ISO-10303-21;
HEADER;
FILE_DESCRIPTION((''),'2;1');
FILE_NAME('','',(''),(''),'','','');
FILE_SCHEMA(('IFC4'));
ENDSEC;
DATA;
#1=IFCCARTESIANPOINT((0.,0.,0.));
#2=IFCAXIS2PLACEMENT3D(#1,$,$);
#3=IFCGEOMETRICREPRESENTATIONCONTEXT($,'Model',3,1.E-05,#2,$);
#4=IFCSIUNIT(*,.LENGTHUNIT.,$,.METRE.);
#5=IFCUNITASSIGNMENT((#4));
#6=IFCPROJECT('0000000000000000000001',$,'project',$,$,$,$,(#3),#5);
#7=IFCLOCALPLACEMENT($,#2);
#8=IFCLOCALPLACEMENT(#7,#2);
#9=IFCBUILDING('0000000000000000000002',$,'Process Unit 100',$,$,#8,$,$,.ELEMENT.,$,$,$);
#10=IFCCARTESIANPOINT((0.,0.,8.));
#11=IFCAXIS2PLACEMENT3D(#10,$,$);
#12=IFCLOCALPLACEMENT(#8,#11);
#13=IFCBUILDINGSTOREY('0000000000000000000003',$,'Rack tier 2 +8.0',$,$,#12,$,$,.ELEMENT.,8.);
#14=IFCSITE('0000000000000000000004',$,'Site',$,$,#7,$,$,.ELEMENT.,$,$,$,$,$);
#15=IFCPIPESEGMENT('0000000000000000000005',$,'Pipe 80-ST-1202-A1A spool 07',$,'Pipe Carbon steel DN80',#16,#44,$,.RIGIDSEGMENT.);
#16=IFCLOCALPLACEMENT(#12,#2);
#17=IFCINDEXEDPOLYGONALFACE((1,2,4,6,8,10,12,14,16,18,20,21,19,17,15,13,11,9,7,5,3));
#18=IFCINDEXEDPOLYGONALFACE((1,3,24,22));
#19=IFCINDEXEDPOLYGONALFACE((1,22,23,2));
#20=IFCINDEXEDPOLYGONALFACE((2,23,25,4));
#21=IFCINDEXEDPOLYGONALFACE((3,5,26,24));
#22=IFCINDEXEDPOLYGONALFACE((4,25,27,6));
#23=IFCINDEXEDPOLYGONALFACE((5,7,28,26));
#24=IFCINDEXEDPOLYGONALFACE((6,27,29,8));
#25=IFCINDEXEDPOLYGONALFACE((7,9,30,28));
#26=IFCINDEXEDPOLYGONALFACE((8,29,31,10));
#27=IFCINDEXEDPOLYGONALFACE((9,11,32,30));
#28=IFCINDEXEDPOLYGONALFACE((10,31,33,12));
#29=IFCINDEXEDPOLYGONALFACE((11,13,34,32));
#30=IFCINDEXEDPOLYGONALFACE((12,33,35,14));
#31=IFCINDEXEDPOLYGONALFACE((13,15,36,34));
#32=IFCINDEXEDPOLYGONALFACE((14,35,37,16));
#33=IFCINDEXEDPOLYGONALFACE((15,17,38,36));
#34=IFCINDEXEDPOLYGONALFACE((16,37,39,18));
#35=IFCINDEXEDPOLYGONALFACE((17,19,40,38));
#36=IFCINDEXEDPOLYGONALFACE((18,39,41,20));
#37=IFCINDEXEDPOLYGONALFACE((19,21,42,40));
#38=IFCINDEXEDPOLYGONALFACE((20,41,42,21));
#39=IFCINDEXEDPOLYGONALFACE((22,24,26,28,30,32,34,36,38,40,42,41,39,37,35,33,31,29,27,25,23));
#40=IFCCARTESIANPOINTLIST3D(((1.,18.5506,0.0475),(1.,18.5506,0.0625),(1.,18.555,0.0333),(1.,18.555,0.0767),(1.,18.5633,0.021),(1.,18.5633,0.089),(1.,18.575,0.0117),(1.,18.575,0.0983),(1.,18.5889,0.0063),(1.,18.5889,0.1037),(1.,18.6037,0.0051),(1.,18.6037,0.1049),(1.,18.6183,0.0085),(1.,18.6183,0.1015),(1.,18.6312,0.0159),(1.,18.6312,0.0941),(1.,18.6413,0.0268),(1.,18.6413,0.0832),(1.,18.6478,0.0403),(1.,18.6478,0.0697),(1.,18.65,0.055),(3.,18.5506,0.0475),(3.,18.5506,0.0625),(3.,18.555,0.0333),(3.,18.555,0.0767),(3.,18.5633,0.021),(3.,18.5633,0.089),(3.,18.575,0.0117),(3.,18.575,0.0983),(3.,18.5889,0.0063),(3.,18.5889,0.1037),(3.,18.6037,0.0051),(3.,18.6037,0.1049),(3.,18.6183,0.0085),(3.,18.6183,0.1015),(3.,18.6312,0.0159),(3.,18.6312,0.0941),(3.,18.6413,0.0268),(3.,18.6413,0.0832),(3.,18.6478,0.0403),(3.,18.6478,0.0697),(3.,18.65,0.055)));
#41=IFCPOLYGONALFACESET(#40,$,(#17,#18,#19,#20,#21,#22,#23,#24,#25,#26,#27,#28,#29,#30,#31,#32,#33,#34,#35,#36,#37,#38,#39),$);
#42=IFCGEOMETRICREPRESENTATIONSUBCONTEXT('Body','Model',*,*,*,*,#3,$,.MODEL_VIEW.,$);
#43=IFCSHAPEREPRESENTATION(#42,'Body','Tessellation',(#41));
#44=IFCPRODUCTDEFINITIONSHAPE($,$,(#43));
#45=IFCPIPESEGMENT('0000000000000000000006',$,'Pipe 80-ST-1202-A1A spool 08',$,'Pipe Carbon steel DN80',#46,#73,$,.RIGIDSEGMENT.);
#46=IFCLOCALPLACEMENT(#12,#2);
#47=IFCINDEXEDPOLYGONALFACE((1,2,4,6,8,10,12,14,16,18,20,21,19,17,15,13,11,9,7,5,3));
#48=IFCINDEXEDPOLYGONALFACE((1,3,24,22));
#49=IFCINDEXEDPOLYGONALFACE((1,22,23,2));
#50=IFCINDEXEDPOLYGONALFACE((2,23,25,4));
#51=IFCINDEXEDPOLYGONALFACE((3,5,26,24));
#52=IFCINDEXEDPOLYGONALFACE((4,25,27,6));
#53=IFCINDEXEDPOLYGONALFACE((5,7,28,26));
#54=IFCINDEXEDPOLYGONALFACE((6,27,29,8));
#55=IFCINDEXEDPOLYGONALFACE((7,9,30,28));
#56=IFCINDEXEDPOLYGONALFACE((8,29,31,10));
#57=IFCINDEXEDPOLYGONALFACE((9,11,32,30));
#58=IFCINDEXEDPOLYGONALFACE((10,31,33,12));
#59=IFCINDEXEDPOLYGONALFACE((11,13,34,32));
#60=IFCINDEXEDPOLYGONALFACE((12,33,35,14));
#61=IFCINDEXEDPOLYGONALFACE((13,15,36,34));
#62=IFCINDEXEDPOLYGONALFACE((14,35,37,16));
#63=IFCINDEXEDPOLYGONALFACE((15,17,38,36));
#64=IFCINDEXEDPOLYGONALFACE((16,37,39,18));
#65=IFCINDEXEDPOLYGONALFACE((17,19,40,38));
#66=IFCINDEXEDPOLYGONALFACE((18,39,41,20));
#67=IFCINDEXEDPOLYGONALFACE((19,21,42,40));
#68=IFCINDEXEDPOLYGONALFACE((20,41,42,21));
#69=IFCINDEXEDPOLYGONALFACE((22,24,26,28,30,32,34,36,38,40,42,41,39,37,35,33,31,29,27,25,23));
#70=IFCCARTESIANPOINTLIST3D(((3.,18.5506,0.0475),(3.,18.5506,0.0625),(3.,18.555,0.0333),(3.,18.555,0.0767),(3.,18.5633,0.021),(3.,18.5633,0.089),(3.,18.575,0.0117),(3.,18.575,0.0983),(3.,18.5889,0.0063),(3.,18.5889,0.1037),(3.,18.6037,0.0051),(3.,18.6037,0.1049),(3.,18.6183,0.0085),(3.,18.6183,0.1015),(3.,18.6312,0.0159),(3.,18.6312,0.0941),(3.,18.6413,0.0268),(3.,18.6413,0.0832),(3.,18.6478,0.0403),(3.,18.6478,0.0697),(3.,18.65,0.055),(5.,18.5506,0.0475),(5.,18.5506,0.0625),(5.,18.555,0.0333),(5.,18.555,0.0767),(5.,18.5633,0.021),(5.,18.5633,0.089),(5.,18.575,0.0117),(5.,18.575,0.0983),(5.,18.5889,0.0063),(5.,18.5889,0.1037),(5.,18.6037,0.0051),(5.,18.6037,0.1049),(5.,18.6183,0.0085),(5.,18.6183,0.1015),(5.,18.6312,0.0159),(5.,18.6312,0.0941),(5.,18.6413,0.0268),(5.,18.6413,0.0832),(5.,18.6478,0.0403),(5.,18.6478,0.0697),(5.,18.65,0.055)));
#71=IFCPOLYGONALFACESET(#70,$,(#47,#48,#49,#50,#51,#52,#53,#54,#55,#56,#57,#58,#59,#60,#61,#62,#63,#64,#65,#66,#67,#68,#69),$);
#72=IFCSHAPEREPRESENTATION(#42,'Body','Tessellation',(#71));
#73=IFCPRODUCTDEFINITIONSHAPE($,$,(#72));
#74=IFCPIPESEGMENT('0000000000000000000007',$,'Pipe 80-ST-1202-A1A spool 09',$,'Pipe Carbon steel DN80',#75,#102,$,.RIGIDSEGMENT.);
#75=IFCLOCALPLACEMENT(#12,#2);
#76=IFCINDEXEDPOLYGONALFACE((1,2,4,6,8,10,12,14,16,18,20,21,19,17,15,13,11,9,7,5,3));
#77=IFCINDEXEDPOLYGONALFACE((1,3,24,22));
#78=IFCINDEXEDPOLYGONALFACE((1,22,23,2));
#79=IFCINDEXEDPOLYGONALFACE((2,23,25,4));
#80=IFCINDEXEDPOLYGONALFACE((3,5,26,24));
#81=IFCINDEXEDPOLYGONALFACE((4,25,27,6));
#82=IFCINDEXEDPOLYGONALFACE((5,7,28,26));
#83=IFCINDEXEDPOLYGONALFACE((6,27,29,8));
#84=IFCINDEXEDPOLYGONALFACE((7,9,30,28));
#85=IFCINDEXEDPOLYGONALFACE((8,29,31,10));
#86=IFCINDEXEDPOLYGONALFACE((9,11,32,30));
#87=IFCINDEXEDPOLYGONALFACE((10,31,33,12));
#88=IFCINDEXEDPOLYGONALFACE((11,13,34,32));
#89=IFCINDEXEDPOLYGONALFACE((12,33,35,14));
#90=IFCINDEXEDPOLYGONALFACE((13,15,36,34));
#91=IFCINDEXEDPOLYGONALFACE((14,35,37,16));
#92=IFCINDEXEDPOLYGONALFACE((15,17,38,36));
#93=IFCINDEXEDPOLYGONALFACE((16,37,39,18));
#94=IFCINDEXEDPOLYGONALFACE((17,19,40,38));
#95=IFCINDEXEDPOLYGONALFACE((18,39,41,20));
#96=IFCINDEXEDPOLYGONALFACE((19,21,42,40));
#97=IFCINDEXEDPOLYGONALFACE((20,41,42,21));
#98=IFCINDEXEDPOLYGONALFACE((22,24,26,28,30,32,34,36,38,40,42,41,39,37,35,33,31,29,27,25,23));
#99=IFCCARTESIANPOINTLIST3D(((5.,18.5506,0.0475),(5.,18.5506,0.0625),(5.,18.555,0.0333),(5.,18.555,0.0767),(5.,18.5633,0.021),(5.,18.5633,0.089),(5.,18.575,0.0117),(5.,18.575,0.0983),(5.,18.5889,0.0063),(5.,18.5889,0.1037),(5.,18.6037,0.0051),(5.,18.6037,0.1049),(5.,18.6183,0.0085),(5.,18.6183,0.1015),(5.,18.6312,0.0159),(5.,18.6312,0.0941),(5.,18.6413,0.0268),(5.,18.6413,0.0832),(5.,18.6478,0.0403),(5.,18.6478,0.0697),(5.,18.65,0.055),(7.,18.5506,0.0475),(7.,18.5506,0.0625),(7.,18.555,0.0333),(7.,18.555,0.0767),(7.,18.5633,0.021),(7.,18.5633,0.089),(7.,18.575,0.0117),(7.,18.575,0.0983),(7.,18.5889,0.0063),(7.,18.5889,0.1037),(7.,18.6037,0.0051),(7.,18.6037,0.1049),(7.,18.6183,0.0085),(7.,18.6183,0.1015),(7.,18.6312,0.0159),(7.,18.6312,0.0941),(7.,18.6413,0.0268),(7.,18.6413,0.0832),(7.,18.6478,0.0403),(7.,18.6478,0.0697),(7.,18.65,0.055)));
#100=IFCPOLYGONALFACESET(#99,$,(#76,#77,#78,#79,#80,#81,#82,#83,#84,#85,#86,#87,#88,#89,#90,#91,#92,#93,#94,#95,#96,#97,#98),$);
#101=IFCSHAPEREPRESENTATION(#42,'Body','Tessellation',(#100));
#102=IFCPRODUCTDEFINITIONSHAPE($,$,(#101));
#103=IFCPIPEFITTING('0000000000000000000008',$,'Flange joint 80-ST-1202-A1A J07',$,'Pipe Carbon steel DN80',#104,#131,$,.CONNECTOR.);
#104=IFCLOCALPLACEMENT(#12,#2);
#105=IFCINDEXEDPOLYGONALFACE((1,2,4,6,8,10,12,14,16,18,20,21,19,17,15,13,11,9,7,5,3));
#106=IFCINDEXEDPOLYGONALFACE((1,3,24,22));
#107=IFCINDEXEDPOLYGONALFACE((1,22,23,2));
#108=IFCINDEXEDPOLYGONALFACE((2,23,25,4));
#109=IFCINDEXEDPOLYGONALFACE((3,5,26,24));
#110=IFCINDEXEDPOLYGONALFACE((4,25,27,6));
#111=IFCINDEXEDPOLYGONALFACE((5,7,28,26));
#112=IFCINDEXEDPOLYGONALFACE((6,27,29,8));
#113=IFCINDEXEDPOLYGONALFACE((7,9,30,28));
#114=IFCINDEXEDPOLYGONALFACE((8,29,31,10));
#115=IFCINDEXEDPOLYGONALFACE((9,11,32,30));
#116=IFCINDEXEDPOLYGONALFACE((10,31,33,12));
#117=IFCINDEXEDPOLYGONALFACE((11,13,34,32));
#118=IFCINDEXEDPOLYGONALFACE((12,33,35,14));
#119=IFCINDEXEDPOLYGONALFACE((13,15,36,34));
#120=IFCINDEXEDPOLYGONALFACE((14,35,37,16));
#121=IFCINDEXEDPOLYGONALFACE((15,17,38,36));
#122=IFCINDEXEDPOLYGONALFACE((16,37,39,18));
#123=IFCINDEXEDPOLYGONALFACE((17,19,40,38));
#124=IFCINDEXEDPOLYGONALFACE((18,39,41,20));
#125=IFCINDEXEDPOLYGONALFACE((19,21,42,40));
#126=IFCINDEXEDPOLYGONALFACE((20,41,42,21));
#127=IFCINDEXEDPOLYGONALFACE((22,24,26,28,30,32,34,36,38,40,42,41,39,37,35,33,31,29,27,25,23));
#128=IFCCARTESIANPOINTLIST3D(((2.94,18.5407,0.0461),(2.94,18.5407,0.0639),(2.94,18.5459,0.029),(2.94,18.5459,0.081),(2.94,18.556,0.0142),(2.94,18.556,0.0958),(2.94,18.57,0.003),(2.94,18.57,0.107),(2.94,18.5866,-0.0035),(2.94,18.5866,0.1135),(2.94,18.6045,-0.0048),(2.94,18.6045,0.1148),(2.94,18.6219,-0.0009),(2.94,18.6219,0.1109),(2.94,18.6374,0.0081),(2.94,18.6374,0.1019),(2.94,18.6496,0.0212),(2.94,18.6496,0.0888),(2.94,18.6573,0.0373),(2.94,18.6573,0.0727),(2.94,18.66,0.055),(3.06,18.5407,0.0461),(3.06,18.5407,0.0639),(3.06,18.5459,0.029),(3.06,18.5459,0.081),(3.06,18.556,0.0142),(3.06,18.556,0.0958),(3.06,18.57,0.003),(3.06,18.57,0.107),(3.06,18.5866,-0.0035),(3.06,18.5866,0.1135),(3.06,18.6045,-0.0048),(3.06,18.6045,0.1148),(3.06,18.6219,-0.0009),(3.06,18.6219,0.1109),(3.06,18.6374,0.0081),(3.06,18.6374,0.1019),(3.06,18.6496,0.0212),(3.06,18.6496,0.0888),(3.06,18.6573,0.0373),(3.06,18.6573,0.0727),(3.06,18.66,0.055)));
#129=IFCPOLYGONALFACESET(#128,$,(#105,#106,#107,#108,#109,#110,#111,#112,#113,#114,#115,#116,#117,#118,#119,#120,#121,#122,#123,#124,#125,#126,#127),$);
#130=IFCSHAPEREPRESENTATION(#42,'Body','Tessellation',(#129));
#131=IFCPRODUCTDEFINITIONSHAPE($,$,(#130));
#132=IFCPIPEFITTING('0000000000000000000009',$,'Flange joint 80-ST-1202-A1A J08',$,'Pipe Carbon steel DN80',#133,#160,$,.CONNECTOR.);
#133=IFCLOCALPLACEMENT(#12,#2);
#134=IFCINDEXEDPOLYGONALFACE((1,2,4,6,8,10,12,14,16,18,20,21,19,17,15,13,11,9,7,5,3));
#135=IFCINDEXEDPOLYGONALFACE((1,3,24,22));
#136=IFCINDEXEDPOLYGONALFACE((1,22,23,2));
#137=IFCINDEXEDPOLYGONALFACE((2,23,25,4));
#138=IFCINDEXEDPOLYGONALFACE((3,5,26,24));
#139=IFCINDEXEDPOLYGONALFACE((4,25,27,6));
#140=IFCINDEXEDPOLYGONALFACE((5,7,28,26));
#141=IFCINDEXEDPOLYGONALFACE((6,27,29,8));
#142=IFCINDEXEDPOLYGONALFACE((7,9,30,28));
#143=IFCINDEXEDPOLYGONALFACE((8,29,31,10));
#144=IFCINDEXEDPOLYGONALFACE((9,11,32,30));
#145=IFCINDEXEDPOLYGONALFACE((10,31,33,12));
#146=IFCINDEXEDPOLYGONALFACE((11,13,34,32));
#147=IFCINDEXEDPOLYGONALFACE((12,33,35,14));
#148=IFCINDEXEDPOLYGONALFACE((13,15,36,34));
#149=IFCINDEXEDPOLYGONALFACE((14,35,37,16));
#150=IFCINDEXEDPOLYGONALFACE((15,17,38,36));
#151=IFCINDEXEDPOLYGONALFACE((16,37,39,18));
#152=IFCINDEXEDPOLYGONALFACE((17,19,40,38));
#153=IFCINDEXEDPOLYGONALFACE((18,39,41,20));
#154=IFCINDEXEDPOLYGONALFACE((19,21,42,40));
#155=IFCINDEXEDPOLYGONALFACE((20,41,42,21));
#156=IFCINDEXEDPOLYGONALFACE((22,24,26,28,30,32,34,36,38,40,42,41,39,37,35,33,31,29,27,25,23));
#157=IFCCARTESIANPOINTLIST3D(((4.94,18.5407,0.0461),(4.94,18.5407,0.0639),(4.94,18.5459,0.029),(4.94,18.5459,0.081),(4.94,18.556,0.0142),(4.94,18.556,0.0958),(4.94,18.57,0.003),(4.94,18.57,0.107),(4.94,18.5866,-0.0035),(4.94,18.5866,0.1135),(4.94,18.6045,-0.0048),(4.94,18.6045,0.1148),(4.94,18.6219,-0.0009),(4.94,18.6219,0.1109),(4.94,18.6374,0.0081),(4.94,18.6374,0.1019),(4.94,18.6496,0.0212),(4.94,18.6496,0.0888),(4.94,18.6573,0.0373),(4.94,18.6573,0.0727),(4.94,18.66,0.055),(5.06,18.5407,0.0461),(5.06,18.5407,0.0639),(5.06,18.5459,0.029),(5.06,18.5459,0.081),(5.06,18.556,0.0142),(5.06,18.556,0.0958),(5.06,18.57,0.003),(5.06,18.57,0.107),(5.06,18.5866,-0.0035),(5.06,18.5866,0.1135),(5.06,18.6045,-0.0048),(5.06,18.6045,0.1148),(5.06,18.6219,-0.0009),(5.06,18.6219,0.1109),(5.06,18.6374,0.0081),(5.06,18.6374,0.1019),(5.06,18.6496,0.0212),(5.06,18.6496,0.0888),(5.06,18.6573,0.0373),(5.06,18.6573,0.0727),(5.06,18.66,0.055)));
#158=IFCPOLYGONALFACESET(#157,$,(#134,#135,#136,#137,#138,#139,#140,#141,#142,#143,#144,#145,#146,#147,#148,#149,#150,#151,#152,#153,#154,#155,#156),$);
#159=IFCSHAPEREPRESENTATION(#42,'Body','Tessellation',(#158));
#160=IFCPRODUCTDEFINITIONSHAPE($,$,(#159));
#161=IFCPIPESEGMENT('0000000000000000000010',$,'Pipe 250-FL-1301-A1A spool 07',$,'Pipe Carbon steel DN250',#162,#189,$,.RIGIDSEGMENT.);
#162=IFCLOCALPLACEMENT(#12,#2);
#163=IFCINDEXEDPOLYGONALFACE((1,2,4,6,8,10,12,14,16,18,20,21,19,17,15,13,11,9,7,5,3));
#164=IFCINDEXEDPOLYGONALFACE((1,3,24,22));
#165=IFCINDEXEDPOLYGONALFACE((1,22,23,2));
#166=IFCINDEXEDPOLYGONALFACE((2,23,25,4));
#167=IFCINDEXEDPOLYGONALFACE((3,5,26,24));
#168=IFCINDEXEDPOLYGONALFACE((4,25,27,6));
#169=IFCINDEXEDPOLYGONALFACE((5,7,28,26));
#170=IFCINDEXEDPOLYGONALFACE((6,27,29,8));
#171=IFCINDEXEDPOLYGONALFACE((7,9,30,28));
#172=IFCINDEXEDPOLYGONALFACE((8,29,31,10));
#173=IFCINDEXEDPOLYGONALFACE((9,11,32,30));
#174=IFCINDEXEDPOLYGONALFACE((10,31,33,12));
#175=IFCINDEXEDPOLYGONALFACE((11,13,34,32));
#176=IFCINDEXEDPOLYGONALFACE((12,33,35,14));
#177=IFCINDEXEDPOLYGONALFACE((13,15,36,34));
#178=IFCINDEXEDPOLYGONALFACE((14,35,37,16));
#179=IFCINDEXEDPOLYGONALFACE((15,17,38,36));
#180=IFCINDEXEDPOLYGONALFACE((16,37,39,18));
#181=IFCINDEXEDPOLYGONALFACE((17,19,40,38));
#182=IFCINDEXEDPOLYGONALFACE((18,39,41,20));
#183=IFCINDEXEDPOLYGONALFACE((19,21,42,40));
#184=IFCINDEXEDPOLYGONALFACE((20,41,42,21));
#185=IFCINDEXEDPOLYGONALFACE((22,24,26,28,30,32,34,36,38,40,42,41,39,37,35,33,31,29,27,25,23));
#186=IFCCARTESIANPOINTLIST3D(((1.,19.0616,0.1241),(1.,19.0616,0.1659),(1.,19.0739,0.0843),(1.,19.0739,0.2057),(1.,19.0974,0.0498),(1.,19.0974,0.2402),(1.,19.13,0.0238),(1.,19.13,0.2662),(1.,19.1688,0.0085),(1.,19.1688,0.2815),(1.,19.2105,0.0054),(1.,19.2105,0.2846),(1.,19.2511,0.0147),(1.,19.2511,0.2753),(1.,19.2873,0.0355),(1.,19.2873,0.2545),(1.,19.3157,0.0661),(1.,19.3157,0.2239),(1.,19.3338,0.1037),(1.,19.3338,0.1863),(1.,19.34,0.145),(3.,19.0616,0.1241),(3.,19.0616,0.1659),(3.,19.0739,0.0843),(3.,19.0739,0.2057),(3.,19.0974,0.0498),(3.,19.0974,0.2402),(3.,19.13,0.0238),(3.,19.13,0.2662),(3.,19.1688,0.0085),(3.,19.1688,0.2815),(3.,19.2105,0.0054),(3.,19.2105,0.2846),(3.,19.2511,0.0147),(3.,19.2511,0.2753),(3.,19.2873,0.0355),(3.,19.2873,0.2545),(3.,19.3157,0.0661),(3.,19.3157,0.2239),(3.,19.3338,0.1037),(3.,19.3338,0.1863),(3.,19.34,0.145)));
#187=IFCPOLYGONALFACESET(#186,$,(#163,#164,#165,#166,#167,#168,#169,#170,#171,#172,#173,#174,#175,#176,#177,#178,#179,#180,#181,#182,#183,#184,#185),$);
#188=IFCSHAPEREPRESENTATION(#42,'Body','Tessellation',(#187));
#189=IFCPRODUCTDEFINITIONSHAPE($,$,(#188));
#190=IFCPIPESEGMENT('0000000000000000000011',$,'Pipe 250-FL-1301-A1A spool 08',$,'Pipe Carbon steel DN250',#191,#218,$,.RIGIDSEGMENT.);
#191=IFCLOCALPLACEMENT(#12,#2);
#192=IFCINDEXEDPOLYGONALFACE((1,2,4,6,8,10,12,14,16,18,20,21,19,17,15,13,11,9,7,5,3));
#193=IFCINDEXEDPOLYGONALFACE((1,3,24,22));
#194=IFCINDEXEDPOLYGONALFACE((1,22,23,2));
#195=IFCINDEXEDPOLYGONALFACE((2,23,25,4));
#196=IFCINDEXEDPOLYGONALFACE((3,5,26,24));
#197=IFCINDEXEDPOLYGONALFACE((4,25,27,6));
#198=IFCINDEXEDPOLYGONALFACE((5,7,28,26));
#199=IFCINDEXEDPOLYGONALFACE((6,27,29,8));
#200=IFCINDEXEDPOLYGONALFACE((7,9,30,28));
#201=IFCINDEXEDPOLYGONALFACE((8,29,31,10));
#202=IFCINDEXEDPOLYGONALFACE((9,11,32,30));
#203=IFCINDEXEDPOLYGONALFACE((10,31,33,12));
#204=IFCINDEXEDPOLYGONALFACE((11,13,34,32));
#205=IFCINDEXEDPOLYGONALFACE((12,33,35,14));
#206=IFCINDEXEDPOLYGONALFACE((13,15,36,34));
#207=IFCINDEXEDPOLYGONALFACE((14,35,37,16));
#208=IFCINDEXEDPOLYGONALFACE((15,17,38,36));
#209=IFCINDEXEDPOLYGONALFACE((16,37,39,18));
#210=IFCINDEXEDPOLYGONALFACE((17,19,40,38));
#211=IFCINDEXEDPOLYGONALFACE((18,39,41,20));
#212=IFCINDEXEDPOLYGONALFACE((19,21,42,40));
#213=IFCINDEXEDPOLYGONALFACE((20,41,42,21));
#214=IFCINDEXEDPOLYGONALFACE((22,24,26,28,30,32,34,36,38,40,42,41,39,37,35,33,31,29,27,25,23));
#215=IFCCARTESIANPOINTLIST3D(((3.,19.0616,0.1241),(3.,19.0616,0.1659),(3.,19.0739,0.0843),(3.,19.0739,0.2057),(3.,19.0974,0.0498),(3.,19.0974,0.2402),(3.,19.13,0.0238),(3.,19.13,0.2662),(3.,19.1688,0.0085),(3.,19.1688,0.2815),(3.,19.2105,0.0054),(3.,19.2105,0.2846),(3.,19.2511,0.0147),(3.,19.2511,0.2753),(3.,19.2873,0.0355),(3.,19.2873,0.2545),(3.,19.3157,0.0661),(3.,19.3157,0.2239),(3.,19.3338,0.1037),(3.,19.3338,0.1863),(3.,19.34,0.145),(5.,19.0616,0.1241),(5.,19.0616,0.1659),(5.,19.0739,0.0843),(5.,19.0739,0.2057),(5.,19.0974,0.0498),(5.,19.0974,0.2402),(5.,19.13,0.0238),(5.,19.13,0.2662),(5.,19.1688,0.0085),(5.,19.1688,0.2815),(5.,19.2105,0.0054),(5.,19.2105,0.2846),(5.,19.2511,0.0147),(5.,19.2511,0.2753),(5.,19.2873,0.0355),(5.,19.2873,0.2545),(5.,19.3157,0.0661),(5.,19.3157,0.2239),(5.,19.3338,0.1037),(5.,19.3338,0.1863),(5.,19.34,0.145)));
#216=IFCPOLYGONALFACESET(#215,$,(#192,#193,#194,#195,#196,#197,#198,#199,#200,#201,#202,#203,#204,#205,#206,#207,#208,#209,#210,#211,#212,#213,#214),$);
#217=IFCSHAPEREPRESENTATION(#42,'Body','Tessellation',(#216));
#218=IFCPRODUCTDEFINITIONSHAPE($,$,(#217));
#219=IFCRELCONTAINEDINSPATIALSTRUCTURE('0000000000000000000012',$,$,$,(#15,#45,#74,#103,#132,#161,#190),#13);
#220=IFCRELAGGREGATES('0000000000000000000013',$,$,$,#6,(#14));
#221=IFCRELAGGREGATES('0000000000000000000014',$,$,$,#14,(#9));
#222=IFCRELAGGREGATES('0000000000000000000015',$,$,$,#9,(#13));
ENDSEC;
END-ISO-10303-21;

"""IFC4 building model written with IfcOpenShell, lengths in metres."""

from ifc_helpers import new_model, si_unit, frame, origin, place, context, subcontext, project, spatial, circle, extrude, element, save


model = new_model("IFC4")

# Units and contexts
model_context = context("Model", 3, precision=1e-05, world=origin())
body_context = subcontext(model_context, "Body", "Model", "MODEL_VIEW")
ifc_project = project(units=[si_unit("LENGTHUNIT", "METRE")], contexts=[model_context])

# Site, building, storey
site_placement = place(None, origin())
site = spatial("IfcSite", under=ifc_project, at=site_placement, Name="Site", CompositionType="ELEMENT")
building_placement = place(site_placement, origin())
building = spatial("IfcBuilding", under=site, at=building_placement, Name="Process Unit 100", CompositionType="ELEMENT")
storey_placement = place(building_placement, frame((0.0, 0.0, 8.0)))
storey = spatial("IfcBuildingStorey", under=building, at=storey_placement, Name="Rack tier 2 +8.0", CompositionType="ELEMENT", Elevation=8.0)

# Pipe segments
for number, where, z_axis, x_axis, name in (
    (1, (1.0, 18.6, 0.055), (1.0, 0.0, 0.0), (0.0, 1.0, 0.0), "Pipe 80-ST-1202-A1A spool 07"),
    (2, (3.0, 18.6, 0.055), (1.0, 0.0, 0.0), (0.0, 1.0, 0.0), "Pipe 80-ST-1202-A1A spool 08"),
    (3, (5.0, 18.6, 0.055), (1.0, 0.0, 0.0), (0.0, 1.0, 0.0), "Pipe 80-ST-1202-A1A spool 09"),
):
    element("IfcPipeSegment", number, at=place(storey_placement, frame(where, z_axis=z_axis, x_axis=x_axis)), inside=storey, Name=name, ObjectType="Pipe Carbon steel DN80", PredefinedType="RIGIDSEGMENT", context=body_context, shape_type="SweptSolid", body=[
        extrude(circle(Radius=0.05), origin(), (0.0, 0.0, 1.0), 2.0),
    ])

# Pipe fittings
for number, where, z_axis, x_axis, name in (
    (4, (2.94, 18.6, 0.055), (1.0, 0.0, 0.0), (0.0, 1.0, 0.0), "Flange joint 80-ST-1202-A1A J07"),
    (5, (4.94, 18.6, 0.055), (1.0, 0.0, 0.0), (0.0, 1.0, 0.0), "Flange joint 80-ST-1202-A1A J08"),
):
    element("IfcPipeFitting", number, at=place(storey_placement, frame(where, z_axis=z_axis, x_axis=x_axis)), inside=storey, Name=name, ObjectType="Pipe Carbon steel DN80", PredefinedType="CONNECTOR", context=body_context, shape_type="SweptSolid", body=[
        extrude(circle(Radius=0.06), origin(), (0.0, 0.0, 1.0), 0.12),
    ])

# Pipe segments
for number, where, z_axis, x_axis, name in (
    (6, (1.0, 19.2, 0.145), (1.0, 0.0, 0.0), (0.0, 1.0, 0.0), "Pipe 250-FL-1301-A1A spool 07"),
    (7, (3.0, 19.2, 0.145), (1.0, 0.0, 0.0), (0.0, 1.0, 0.0), "Pipe 250-FL-1301-A1A spool 08"),
):
    element("IfcPipeSegment", number, at=place(storey_placement, frame(where, z_axis=z_axis, x_axis=x_axis)), inside=storey, Name=name, ObjectType="Pipe Carbon steel DN250", PredefinedType="RIGIDSEGMENT", context=body_context, shape_type="SweptSolid", body=[
        extrude(circle(Radius=0.14), origin(), (0.0, 0.0, 1.0), 2.0),
    ])

save(model, "model.ifc")
